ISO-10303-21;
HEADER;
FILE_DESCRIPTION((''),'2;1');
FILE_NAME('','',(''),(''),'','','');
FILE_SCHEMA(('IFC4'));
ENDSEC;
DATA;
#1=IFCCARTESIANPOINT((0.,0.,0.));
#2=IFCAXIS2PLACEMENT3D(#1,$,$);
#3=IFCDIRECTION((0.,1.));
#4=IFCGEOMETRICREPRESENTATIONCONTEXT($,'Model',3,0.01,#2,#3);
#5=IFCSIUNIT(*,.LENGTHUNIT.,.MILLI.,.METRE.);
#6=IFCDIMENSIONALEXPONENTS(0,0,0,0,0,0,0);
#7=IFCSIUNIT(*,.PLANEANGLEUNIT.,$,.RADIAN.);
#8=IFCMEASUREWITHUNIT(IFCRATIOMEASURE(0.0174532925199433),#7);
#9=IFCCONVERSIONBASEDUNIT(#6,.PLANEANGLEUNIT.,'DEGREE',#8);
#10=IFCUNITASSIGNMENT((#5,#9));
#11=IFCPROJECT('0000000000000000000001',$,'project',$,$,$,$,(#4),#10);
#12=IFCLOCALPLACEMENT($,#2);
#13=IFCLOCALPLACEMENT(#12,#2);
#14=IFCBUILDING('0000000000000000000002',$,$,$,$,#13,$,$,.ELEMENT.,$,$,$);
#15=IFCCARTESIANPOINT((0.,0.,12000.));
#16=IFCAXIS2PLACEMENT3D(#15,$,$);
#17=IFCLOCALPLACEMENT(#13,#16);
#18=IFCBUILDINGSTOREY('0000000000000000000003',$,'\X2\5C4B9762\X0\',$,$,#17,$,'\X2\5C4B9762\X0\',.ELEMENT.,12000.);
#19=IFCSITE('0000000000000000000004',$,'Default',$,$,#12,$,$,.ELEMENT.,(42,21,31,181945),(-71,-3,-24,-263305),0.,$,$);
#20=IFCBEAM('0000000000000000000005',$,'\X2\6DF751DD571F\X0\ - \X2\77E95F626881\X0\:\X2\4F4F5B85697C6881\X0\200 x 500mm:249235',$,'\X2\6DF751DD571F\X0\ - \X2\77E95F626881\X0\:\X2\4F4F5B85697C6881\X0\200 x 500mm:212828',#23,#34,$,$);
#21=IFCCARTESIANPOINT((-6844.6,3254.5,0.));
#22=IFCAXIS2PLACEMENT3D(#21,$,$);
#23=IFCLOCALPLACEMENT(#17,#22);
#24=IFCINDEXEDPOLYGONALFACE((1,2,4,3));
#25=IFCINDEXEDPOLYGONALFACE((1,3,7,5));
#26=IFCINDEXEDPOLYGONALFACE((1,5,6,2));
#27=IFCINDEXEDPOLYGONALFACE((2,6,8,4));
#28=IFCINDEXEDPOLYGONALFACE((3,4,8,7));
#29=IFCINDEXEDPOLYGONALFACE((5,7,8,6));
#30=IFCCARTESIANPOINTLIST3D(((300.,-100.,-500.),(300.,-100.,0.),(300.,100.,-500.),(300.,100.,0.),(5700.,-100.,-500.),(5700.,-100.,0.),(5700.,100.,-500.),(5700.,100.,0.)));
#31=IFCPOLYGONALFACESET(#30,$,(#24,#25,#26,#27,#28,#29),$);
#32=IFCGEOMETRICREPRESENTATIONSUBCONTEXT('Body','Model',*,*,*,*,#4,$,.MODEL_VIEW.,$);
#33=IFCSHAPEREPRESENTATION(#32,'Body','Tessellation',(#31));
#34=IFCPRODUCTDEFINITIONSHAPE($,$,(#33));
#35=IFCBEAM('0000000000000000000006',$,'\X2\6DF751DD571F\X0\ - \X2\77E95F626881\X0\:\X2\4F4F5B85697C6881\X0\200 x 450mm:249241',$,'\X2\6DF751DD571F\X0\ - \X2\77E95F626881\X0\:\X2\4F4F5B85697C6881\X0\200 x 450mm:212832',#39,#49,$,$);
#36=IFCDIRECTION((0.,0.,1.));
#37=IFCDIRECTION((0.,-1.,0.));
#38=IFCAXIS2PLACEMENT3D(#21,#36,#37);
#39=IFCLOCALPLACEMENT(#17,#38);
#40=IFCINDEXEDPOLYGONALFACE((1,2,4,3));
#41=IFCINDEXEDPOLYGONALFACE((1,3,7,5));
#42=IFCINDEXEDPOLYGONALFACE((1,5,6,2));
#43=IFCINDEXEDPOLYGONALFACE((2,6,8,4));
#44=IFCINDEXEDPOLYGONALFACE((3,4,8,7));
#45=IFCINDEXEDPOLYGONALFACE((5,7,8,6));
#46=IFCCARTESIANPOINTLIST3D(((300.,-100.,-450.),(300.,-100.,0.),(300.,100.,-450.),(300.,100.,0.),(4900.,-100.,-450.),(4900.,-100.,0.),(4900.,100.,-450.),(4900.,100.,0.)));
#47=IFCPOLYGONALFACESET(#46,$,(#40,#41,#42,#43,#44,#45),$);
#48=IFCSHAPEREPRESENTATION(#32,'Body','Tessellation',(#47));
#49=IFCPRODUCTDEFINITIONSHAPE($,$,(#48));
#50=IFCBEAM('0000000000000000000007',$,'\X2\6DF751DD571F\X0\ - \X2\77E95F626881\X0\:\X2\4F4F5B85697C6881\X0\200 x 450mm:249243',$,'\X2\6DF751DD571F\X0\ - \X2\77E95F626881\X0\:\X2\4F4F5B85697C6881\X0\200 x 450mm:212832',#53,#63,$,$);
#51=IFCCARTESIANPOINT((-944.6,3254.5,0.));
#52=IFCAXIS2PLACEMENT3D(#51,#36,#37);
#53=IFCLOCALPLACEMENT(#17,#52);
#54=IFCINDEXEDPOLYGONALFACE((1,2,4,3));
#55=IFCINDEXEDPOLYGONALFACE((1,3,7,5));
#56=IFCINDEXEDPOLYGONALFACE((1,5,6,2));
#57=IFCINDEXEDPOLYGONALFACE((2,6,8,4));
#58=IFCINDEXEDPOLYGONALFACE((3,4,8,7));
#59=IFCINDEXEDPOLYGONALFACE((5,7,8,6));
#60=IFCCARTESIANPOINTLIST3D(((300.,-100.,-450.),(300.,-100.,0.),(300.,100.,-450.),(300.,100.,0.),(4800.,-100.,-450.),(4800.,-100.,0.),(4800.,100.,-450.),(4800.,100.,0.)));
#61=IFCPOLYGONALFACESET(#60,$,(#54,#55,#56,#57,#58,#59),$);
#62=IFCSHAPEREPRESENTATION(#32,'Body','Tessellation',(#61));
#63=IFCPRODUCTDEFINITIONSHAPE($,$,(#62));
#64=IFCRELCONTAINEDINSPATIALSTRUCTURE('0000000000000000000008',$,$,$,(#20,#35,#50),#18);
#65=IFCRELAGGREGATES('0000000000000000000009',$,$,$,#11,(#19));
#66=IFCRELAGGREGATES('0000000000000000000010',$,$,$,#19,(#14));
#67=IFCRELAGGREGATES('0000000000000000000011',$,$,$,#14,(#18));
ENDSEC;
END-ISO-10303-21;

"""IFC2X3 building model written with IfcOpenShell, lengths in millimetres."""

from ifc_helpers import new_model, entity, si_unit, converted_unit, direction, frame, frame_2d, origin, place, context, subcontext, project, spatial, rectangle, extrude, element, save


model = new_model("IFC2X3")

# Units and contexts
model_context = context("Model", 3, precision=0.01, world=origin(), true_north=direction((0.0, 1.0)))
body_context = subcontext(model_context, "Body", "Model", "MODEL_VIEW")
ifc_project = project(units=[si_unit("LENGTHUNIT", "METRE", prefix="MILLI"), converted_unit("PLANEANGLEUNIT", "DEGREE", entity("IfcRatioMeasure", 0.0174532925199433), si_unit("PLANEANGLEUNIT", "RADIAN"), dimensions=[0, 0, 0, 0, 0, 0, 0])], contexts=[model_context])

# Site, building, storey
site_placement = place(None, origin())
site = spatial("IfcSite", under=ifc_project, at=site_placement, Name="Default", CompositionType="ELEMENT", RefLatitude=(42, 21, 31, 181945), RefLongitude=(-71, -3, -24, -263305), RefElevation=0.0)
building_placement = place(site_placement, origin())
building = spatial("IfcBuilding", under=site, at=building_placement, CompositionType="ELEMENT")
storey_placement = place(building_placement, frame((0.0, 0.0, 12000.0)))
storey = spatial("IfcBuildingStorey", under=building, at=storey_placement, Name="屋面", LongName="屋面", CompositionType="ELEMENT", Elevation=12000.0)

# Beams
beam_1_placement = place(storey_placement, frame((-6844.6, 3254.5, 0.0)))
element("IfcBeam", 1, at=beam_1_placement, inside=storey, Name="混凝土 - 矩形梁:住宅楼梁200 x 500mm:249235", ObjectType="混凝土 - 矩形梁:住宅楼梁200 x 500mm:212828", context=body_context, shape_type="SweptSolid", body=[
    extrude(rectangle(XDim=500.0, YDim=200.0, at=frame_2d((0.0, 0.0), x_axis=(1.0, 0.0))), frame((300.0, 0.0, -250.0), z_axis=(1.0, 0.0, 0.0), x_axis=(0.0, 0.0, -1.0)), (0.0, 0.0, 1.0), 5400.0),
])
beam_2_placement = place(storey_placement, frame((-6844.6, 3254.5, 0.0), z_axis=(0.0, 0.0, 1.0), x_axis=(0.0, -1.0, 0.0)))
element("IfcBeam", 2, at=beam_2_placement, inside=storey, Name="混凝土 - 矩形梁:住宅楼梁200 x 450mm:249241", ObjectType="混凝土 - 矩形梁:住宅楼梁200 x 450mm:212832", context=body_context, shape_type="SweptSolid", body=[
    extrude(rectangle(XDim=450.0, YDim=200.0, at=frame_2d((0.0, 0.0), x_axis=(1.0, 0.0))), frame((300.0, 0.0, -225.0), z_axis=(1.0, 0.0, 0.0), x_axis=(0.0, 0.0, -1.0)), (0.0, 0.0, 1.0), 4600.0),
])
beam_3_placement = place(storey_placement, frame((-944.6, 3254.5, 0.0), z_axis=(0.0, 0.0, 1.0), x_axis=(0.0, -1.0, 0.0)))
element("IfcBeam", 3, at=beam_3_placement, inside=storey, Name="混凝土 - 矩形梁:住宅楼梁200 x 450mm:249243", ObjectType="混凝土 - 矩形梁:住宅楼梁200 x 450mm:212832", context=body_context, shape_type="SweptSolid", body=[
    extrude(rectangle(XDim=450.0, YDim=200.0, at=frame_2d((0.0, 0.0), x_axis=(1.0, 0.0))), frame((300.0, 0.0, -225.0), z_axis=(1.0, 0.0, 0.0), x_axis=(0.0, 0.0, -1.0)), (0.0, 0.0, 1.0), 4500.0),
])

save(model, "model.ifc")
